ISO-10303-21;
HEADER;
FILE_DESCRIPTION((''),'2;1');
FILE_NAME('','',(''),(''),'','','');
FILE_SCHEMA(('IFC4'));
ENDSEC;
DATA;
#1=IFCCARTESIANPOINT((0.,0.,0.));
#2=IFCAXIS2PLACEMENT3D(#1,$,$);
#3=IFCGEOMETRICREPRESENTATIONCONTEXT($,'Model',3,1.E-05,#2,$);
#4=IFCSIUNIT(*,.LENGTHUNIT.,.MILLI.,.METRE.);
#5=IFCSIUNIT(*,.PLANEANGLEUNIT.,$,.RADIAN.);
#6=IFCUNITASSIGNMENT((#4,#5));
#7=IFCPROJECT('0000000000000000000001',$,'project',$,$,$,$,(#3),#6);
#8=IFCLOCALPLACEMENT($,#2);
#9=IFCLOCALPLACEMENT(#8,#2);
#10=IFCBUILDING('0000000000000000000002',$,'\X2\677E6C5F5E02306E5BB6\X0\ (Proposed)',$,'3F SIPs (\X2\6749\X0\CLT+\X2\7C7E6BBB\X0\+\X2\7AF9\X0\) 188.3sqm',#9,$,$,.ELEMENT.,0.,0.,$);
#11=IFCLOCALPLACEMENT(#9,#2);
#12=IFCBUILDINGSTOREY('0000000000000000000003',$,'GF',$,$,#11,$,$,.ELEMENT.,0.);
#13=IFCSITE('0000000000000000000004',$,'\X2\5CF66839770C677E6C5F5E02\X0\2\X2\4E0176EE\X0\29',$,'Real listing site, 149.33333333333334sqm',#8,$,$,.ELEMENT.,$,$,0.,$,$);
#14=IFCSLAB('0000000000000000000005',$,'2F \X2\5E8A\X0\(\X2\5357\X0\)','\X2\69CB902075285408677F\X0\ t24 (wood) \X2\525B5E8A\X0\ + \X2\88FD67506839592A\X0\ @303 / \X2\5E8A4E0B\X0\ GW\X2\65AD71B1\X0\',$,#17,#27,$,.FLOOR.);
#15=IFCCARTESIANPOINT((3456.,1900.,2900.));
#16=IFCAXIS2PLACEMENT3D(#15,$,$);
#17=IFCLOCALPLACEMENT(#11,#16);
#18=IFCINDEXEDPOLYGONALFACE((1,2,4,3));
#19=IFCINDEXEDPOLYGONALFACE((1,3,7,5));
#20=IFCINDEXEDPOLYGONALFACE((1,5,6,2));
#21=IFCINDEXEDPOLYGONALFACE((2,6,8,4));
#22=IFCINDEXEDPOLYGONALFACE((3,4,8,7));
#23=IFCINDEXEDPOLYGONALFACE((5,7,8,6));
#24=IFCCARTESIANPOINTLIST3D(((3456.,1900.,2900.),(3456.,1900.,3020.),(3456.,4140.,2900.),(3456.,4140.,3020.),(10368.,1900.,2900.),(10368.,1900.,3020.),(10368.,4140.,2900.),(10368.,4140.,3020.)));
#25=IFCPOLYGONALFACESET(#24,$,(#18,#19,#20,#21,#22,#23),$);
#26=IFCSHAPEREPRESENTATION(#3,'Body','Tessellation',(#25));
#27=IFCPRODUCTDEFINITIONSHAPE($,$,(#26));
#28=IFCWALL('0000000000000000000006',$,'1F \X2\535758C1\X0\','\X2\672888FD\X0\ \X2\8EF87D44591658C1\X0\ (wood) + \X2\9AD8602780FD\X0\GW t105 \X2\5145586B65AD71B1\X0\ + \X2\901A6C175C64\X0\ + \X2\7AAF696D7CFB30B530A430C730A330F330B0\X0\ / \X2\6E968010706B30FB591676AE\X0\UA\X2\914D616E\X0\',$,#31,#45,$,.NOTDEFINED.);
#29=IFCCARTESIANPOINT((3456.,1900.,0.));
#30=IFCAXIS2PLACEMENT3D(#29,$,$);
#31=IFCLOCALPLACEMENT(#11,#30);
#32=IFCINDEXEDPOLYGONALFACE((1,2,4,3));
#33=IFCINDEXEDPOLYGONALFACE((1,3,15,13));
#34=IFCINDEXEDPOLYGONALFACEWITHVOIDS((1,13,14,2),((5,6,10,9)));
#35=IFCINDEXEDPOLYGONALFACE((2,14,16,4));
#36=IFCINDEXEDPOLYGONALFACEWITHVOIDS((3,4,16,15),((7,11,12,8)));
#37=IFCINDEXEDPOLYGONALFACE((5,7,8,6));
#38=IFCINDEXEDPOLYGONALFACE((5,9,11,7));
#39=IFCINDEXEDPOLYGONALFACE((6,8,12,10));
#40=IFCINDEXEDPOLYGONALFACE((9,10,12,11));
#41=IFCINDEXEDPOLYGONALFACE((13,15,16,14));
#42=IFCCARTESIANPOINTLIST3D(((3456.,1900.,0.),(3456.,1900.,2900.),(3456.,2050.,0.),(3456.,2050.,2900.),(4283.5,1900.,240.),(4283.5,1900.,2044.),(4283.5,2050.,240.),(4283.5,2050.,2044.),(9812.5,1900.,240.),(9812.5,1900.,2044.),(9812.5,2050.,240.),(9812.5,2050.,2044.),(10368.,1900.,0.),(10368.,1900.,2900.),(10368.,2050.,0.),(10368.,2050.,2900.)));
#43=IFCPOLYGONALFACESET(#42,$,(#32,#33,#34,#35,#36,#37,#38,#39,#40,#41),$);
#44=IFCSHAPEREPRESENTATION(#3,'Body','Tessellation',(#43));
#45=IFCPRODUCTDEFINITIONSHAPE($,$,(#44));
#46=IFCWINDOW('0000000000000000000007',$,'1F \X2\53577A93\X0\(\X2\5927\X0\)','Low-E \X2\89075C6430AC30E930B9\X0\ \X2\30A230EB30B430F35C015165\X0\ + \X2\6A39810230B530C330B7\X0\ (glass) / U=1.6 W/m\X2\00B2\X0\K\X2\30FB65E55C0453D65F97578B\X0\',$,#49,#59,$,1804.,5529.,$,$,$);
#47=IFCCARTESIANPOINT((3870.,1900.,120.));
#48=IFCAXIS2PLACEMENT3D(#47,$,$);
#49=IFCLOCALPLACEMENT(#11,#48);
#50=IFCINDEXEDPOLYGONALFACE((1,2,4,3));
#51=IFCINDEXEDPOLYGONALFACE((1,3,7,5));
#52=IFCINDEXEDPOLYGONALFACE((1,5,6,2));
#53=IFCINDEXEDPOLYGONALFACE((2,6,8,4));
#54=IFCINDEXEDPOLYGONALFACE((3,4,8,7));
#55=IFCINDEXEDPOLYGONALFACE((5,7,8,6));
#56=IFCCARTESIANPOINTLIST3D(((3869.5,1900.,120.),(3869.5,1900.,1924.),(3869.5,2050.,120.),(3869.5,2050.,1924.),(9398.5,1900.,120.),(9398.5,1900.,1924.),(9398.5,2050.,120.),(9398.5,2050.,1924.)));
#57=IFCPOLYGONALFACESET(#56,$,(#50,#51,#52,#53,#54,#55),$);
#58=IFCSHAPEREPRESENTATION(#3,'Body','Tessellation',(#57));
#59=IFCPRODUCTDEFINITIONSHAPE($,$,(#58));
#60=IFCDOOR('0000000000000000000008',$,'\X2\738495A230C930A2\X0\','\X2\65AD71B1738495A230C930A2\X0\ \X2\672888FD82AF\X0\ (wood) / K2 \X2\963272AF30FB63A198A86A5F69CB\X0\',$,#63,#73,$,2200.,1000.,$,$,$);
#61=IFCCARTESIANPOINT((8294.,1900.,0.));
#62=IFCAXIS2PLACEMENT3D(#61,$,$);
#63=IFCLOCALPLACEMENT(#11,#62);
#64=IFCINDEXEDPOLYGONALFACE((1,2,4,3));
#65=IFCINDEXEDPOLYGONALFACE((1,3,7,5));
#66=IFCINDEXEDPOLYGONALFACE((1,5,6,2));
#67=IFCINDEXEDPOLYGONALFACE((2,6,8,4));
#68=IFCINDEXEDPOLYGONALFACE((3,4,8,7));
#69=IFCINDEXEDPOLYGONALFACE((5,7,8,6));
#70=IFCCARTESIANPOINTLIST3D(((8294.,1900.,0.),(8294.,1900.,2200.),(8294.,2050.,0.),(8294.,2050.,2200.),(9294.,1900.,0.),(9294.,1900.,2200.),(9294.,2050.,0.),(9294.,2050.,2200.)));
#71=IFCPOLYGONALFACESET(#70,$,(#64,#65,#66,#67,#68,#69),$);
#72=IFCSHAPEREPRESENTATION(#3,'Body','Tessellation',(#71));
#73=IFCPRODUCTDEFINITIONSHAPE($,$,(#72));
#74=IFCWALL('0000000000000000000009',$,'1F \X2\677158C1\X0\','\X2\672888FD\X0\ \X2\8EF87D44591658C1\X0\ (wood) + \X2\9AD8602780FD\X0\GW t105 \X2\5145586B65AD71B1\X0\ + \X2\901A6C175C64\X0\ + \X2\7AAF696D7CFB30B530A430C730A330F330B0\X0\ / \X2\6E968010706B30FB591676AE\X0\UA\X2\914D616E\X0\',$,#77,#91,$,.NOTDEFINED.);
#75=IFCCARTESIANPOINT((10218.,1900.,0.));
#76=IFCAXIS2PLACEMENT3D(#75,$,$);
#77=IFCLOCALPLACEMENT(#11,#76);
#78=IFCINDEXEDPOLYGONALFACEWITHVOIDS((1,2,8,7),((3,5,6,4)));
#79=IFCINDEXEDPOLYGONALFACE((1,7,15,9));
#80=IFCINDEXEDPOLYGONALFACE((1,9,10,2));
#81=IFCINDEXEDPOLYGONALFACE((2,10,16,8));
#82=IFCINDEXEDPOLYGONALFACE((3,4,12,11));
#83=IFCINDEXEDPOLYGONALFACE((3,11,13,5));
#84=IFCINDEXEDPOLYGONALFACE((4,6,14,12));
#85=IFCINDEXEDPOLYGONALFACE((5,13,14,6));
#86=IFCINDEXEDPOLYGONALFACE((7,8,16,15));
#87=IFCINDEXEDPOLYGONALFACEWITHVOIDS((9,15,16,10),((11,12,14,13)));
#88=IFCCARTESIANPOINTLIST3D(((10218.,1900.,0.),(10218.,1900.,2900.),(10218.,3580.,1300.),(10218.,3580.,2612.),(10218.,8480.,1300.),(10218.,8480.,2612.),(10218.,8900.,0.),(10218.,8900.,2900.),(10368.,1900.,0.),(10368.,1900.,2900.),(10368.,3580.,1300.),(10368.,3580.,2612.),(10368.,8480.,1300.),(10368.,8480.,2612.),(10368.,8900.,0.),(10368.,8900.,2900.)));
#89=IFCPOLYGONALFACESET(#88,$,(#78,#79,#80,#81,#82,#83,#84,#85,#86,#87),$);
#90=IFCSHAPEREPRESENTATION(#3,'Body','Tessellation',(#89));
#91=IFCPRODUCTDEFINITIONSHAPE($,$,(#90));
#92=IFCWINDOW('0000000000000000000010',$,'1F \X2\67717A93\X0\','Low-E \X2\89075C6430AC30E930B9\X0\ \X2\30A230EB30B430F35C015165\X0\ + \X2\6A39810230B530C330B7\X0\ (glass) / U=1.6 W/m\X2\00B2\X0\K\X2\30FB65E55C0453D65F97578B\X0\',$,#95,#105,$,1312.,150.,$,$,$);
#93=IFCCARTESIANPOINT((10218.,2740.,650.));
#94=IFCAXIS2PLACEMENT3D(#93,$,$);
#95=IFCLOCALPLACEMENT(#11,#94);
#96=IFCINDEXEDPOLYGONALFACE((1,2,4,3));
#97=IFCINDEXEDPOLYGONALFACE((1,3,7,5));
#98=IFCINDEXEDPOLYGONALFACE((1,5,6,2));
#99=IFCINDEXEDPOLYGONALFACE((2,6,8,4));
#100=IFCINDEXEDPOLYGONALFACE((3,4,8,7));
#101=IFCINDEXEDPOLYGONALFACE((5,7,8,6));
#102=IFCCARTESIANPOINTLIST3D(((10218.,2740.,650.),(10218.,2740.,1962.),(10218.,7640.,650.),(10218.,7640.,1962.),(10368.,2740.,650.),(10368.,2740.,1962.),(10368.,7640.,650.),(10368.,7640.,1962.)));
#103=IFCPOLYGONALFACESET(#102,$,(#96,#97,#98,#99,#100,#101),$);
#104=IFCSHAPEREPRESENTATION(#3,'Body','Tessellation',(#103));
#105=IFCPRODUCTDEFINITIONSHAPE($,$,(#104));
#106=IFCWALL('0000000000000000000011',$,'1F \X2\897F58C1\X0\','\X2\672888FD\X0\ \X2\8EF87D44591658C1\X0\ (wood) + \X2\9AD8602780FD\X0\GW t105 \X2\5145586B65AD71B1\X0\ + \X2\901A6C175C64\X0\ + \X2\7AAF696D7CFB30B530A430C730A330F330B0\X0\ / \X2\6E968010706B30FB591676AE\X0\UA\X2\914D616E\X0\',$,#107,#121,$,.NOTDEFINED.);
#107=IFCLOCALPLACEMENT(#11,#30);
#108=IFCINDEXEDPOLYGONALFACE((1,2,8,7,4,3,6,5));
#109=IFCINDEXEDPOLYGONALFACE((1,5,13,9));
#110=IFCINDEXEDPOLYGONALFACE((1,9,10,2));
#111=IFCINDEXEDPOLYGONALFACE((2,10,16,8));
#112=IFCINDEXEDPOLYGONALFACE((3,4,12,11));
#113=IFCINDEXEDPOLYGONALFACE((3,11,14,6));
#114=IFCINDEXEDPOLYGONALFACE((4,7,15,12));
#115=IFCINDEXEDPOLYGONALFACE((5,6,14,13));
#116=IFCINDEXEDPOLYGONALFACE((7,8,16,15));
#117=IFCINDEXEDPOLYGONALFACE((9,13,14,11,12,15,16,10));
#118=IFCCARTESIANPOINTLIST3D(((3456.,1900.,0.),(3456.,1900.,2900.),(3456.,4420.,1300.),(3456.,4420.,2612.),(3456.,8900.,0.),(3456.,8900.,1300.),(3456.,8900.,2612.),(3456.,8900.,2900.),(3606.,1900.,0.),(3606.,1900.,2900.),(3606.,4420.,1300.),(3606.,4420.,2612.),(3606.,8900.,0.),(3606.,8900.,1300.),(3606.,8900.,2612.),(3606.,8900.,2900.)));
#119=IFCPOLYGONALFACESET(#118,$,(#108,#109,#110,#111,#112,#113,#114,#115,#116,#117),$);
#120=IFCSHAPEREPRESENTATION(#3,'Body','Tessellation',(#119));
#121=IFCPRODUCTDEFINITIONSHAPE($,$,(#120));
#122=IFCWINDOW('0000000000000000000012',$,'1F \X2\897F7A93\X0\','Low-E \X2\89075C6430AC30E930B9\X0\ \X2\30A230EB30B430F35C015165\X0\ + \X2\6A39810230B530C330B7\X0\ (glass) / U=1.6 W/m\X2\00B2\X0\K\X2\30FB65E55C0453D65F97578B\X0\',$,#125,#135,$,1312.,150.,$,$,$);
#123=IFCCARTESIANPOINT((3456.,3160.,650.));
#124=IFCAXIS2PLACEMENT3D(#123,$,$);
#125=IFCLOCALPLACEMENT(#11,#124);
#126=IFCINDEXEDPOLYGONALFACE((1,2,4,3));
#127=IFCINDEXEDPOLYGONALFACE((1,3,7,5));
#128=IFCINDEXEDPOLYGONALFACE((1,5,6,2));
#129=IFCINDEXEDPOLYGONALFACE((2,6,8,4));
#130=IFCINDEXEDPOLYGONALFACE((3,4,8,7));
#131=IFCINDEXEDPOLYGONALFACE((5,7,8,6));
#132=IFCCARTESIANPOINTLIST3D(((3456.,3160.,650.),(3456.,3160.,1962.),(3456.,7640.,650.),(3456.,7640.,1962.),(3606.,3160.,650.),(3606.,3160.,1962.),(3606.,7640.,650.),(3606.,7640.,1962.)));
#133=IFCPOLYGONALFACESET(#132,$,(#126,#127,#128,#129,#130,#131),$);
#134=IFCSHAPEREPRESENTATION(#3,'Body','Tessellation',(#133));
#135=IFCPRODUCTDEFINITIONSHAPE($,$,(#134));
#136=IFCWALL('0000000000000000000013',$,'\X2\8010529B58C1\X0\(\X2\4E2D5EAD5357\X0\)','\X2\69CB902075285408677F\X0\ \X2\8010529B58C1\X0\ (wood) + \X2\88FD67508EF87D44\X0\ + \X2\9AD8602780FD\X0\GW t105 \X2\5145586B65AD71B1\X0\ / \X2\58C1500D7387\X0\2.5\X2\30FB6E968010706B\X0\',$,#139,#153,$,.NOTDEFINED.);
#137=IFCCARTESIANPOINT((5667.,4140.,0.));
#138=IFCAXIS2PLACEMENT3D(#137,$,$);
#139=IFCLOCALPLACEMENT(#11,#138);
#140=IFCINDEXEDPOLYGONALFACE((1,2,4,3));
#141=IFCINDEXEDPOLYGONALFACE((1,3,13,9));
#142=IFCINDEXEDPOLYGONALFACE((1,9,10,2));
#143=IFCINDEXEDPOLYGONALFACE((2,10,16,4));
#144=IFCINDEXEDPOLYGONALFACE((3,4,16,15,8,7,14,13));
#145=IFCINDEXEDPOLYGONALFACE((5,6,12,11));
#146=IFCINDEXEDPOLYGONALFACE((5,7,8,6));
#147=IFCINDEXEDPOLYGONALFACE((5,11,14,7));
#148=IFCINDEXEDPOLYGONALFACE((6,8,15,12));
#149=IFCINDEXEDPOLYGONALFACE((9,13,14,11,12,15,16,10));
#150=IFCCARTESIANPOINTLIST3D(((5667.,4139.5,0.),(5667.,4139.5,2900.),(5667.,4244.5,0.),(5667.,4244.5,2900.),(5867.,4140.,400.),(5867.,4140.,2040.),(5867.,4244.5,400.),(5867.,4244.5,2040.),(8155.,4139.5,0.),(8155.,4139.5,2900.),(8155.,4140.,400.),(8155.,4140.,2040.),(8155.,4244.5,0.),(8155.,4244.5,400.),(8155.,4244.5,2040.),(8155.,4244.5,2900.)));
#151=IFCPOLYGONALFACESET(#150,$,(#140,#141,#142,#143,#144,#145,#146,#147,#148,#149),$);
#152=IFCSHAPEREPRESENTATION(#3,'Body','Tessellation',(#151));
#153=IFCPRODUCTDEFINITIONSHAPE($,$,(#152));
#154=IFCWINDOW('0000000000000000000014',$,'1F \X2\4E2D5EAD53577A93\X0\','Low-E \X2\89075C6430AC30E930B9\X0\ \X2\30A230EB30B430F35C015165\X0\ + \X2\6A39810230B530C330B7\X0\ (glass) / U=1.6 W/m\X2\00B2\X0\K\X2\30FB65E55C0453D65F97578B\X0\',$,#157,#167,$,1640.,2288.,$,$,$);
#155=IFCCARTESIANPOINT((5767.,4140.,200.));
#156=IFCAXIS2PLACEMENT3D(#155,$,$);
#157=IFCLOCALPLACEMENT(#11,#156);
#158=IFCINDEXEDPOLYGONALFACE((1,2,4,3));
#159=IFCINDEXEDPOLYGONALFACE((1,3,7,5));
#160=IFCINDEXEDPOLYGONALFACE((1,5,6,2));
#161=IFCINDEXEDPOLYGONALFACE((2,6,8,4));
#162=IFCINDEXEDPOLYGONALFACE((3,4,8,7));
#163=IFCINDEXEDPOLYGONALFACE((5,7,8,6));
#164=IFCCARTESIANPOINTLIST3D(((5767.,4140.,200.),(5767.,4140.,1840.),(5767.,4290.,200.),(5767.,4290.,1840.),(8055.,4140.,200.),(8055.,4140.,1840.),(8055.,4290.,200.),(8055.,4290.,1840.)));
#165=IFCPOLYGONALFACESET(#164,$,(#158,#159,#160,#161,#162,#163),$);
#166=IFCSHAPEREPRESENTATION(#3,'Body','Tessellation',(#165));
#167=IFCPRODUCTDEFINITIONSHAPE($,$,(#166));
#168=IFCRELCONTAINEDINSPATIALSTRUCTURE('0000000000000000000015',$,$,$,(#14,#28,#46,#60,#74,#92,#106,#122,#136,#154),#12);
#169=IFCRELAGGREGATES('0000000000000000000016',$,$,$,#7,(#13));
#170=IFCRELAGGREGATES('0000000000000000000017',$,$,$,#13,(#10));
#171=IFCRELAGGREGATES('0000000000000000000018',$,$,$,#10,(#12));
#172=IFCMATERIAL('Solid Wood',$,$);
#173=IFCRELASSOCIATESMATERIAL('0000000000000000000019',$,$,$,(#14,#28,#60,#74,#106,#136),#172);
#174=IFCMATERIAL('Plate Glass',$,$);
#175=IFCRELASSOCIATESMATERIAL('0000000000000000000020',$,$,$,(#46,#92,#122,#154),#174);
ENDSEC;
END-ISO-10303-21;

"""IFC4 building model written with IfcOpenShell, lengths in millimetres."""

from ifc_helpers import new_model, si_unit, frame, frame_2d, origin, place, context, project, spatial, rectangle, extrude, material, element, fill, save


model = new_model("IFC4")

# Units and contexts
model_context = context("Model", 3, precision=1e-05, world=origin())
ifc_project = project(units=[si_unit("LENGTHUNIT", "METRE", prefix="MILLI"), si_unit("PLANEANGLEUNIT", "RADIAN")], contexts=[model_context])

# Site, building, storey
site_placement = place(None, origin())
site = spatial("IfcSite", under=ifc_project, at=site_placement, Name="島根県松江市2丁目29", ObjectType="Real listing site, 149.33333333333334sqm", CompositionType="ELEMENT", RefElevation=0.0)
building_placement = place(site_placement, origin())
building = spatial("IfcBuilding", under=site, at=building_placement, Name="松江市の家 (Proposed)", ObjectType="3F SIPs (杉CLT+籾殻+竹) 188.3sqm", CompositionType="ELEMENT", ElevationOfRefHeight=0.0, ElevationOfTerrain=0.0)
storey_placement = place(building_placement, origin())
storey = spatial("IfcBuildingStorey", under=building, at=storey_placement, Name="GF", CompositionType="ELEMENT", Elevation=0.0)

# Slab
ifc_material_1 = material(Name="Solid Wood")
slab_1_placement = place(storey_placement, frame((3456.0, 1900.0, 2900.0)))
element("IfcSlab", 1, at=slab_1_placement, inside=storey, material=ifc_material_1, Name="2F 床(南)", Description="構造用合板 t24 (wood) 剛床 + 製材根太 @303 / 床下 GW断熱", PredefinedType="FLOOR", context=model_context, shape_type="SweptSolid", body=[
    extrude(rectangle(XDim=6912.0, YDim=2240.0, at=frame_2d((3456.0, 1120.0))), frame((3456.0, 1900.0, 2900.0)), (0.0, 0.0, 1.0), 120.0),
])

# Wall, openings, window, door
wall_1_placement = place(storey_placement, frame((3456.0, 1900.0, 0.0)))
wall_1 = element("IfcWall", 2, at=wall_1_placement, inside=storey, material=ifc_material_1, Name="1F 南壁", Description="木製 軸組外壁 (wood) + 高性能GW t105 充填断熱 + 通気層 + 窯業系サイディング / 準耐火・外皮UA配慮", PredefinedType="NOTDEFINED", context=model_context, shape_type="SweptSolid", body=[
    extrude(rectangle(XDim=6912.0, YDim=150.0, at=frame_2d((3456.0, 75.0))), frame((3456.0, 1900.0, 0.0)), (0.0, 0.0, 1.0), 2900.0),
])
opening_1_placement = place(storey_placement, frame((3870.0, 1900.0, 120.0)))
opening_1 = element("IfcOpeningElement", 3, at=opening_1_placement, cuts=wall_1, PredefinedType="NOTDEFINED", context=model_context, shape_type="SweptSolid", body=[
    extrude(rectangle(XDim=5529.0, YDim=150.0, at=frame_2d((2764.0, 75.0))), frame((3870.0, 1900.0, 120.0)), (0.0, 0.0, 1.0), 1804.0),
])
opening_2_placement = place(storey_placement, frame((8294.0, 1900.0, 0.0)))
opening_2 = element("IfcOpeningElement", 4, at=opening_2_placement, cuts=wall_1, PredefinedType="NOTDEFINED", context=model_context, shape_type="SweptSolid", body=[
    extrude(rectangle(XDim=1000.0, YDim=150.0, at=frame_2d((500.0, 75.0))), frame((8294.0, 1900.0, 0.0)), (0.0, 0.0, 1.0), 2200.0),
])
ifc_material_2 = material(Name="Plate Glass")
window_1_placement = place(storey_placement, frame((3870.0, 1900.0, 120.0)))
window_1 = element("IfcWindow", 5, at=window_1_placement, inside=storey, material=ifc_material_2, Name="1F 南窓(大)", Description="Low-E 複層ガラス アルゴン封入 + 樹脂サッシ (glass) / U=1.6 W/m²K・日射取得型", OverallHeight=1804.0, OverallWidth=5529.0, context=model_context, shape_type="SweptSolid", body=[
    extrude(rectangle(XDim=5529.0, YDim=150.0, at=frame_2d((2764.0, 75.0))), frame((3870.0, 1900.0, 120.0)), (0.0, 0.0, 1.0), 1804.0),
])
fill(opening_1, window_1)
door_placement = place(storey_placement, frame((8294.0, 1900.0, 0.0)))
door = element("IfcDoor", 6, at=door_placement, inside=storey, material=ifc_material_1, Name="玄関ドア", Description="断熱玄関ドア 木製芯 (wood) / K2 防犯・採風機構", OverallHeight=2200.0, OverallWidth=1000.0, context=model_context, shape_type="SweptSolid", body=[
    extrude(rectangle(XDim=1000.0, YDim=150.0, at=frame_2d((500.0, 75.0))), frame((8294.0, 1900.0, 0.0)), (0.0, 0.0, 1.0), 2200.0),
])
fill(opening_2, door)

# Walls, openings, windows
wall_2_placement = place(storey_placement, frame((10218.0, 1900.0, 0.0)))
wall_2 = element("IfcWall", 7, at=wall_2_placement, inside=storey, material=ifc_material_1, Name="1F 東壁", Description="木製 軸組外壁 (wood) + 高性能GW t105 充填断熱 + 通気層 + 窯業系サイディング / 準耐火・外皮UA配慮", PredefinedType="NOTDEFINED", context=model_context, shape_type="SweptSolid", body=[
    extrude(rectangle(XDim=150.0, YDim=7000.0, at=frame_2d((75.0, 3500.0))), frame((10218.0, 1900.0, 0.0)), (0.0, 0.0, 1.0), 2900.0),
])
opening_3_placement = place(storey_placement, frame((10218.0, 2740.0, 650.0)))
opening_3 = element("IfcOpeningElement", 8, at=opening_3_placement, cuts=wall_2, PredefinedType="NOTDEFINED", context=model_context, shape_type="SweptSolid", body=[
    extrude(rectangle(XDim=150.0, YDim=4900.0, at=frame_2d((75.0, 2450.0))), frame((10218.0, 2740.0, 650.0)), (0.0, 0.0, 1.0), 1312.0),
])
window_2_placement = place(storey_placement, frame((10218.0, 2740.0, 650.0)))
window_2 = element("IfcWindow", 9, at=window_2_placement, inside=storey, material=ifc_material_2, Name="1F 東窓", Description="Low-E 複層ガラス アルゴン封入 + 樹脂サッシ (glass) / U=1.6 W/m²K・日射取得型", OverallHeight=1312.0, OverallWidth=150.0, context=model_context, shape_type="SweptSolid", body=[
    extrude(rectangle(XDim=150.0, YDim=4900.0, at=frame_2d((75.0, 2450.0))), frame((10218.0, 2740.0, 650.0)), (0.0, 0.0, 1.0), 1312.0),
])
fill(opening_3, window_2)
wall_3_placement = place(storey_placement, frame((3456.0, 1900.0, 0.0)))
wall_3 = element("IfcWall", 10, at=wall_3_placement, inside=storey, material=ifc_material_1, Name="1F 西壁", Description="木製 軸組外壁 (wood) + 高性能GW t105 充填断熱 + 通気層 + 窯業系サイディング / 準耐火・外皮UA配慮", PredefinedType="NOTDEFINED", context=model_context, shape_type="SweptSolid", body=[
    extrude(rectangle(XDim=150.0, YDim=7000.0, at=frame_2d((75.0, 3500.0))), frame((3456.0, 1900.0, 0.0)), (0.0, 0.0, 1.0), 2900.0),
])
opening_4_placement = place(storey_placement, frame((3456.0, 3160.0, 650.0)))
opening_4 = element("IfcOpeningElement", 11, at=opening_4_placement, cuts=wall_3, PredefinedType="NOTDEFINED", context=model_context, shape_type="SweptSolid", body=[
    extrude(rectangle(XDim=150.0, YDim=4480.0, at=frame_2d((75.0, 2240.0))), frame((3456.0, 3160.0, 650.0)), (0.0, 0.0, 1.0), 1312.0),
])
window_3_placement = place(storey_placement, frame((3456.0, 3160.0, 650.0)))
window_3 = element("IfcWindow", 12, at=window_3_placement, inside=storey, material=ifc_material_2, Name="1F 西窓", Description="Low-E 複層ガラス アルゴン封入 + 樹脂サッシ (glass) / U=1.6 W/m²K・日射取得型", OverallHeight=1312.0, OverallWidth=150.0, context=model_context, shape_type="SweptSolid", body=[
    extrude(rectangle(XDim=150.0, YDim=4480.0, at=frame_2d((75.0, 2240.0))), frame((3456.0, 3160.0, 650.0)), (0.0, 0.0, 1.0), 1312.0),
])
fill(opening_4, window_3)
wall_4_placement = place(storey_placement, frame((5667.0, 4140.0, 0.0)))
wall_4 = element("IfcWall", 13, at=wall_4_placement, inside=storey, material=ifc_material_1, Name="耐力壁(中庭南)", Description="構造用合板 耐力壁 (wood) + 製材軸組 + 高性能GW t105 充填断熱 / 壁倍率2.5・準耐火", PredefinedType="NOTDEFINED", context=model_context, shape_type="SweptSolid", body=[
    extrude(rectangle(XDim=2488.0, YDim=105.0, at=frame_2d((1244.0, 52.0))), frame((5667.0, 4140.0, 0.0)), (0.0, 0.0, 1.0), 2900.0),
])
opening_5_placement = place(storey_placement, frame((5767.0, 4140.0, 200.0)))
opening_5 = element("IfcOpeningElement", 14, at=opening_5_placement, cuts=wall_4, PredefinedType="NOTDEFINED", context=model_context, shape_type="SweptSolid", body=[
    extrude(rectangle(XDim=2288.0, YDim=150.0, at=frame_2d((1144.0, 75.0))), frame((5767.0, 4140.0, 200.0)), (0.0, 0.0, 1.0), 1640.0),
])
window_4_placement = place(storey_placement, frame((5767.0, 4140.0, 200.0)))
window_4 = element("IfcWindow", 15, at=window_4_placement, inside=storey, material=ifc_material_2, Name="1F 中庭南窓", Description="Low-E 複層ガラス アルゴン封入 + 樹脂サッシ (glass) / U=1.6 W/m²K・日射取得型", OverallHeight=1640.0, OverallWidth=2288.0, context=model_context, shape_type="SweptSolid", body=[
    extrude(rectangle(XDim=2288.0, YDim=150.0, at=frame_2d((1144.0, 75.0))), frame((5767.0, 4140.0, 200.0)), (0.0, 0.0, 1.0), 1640.0),
])
fill(opening_5, window_4)

save(model, "model.ifc")
